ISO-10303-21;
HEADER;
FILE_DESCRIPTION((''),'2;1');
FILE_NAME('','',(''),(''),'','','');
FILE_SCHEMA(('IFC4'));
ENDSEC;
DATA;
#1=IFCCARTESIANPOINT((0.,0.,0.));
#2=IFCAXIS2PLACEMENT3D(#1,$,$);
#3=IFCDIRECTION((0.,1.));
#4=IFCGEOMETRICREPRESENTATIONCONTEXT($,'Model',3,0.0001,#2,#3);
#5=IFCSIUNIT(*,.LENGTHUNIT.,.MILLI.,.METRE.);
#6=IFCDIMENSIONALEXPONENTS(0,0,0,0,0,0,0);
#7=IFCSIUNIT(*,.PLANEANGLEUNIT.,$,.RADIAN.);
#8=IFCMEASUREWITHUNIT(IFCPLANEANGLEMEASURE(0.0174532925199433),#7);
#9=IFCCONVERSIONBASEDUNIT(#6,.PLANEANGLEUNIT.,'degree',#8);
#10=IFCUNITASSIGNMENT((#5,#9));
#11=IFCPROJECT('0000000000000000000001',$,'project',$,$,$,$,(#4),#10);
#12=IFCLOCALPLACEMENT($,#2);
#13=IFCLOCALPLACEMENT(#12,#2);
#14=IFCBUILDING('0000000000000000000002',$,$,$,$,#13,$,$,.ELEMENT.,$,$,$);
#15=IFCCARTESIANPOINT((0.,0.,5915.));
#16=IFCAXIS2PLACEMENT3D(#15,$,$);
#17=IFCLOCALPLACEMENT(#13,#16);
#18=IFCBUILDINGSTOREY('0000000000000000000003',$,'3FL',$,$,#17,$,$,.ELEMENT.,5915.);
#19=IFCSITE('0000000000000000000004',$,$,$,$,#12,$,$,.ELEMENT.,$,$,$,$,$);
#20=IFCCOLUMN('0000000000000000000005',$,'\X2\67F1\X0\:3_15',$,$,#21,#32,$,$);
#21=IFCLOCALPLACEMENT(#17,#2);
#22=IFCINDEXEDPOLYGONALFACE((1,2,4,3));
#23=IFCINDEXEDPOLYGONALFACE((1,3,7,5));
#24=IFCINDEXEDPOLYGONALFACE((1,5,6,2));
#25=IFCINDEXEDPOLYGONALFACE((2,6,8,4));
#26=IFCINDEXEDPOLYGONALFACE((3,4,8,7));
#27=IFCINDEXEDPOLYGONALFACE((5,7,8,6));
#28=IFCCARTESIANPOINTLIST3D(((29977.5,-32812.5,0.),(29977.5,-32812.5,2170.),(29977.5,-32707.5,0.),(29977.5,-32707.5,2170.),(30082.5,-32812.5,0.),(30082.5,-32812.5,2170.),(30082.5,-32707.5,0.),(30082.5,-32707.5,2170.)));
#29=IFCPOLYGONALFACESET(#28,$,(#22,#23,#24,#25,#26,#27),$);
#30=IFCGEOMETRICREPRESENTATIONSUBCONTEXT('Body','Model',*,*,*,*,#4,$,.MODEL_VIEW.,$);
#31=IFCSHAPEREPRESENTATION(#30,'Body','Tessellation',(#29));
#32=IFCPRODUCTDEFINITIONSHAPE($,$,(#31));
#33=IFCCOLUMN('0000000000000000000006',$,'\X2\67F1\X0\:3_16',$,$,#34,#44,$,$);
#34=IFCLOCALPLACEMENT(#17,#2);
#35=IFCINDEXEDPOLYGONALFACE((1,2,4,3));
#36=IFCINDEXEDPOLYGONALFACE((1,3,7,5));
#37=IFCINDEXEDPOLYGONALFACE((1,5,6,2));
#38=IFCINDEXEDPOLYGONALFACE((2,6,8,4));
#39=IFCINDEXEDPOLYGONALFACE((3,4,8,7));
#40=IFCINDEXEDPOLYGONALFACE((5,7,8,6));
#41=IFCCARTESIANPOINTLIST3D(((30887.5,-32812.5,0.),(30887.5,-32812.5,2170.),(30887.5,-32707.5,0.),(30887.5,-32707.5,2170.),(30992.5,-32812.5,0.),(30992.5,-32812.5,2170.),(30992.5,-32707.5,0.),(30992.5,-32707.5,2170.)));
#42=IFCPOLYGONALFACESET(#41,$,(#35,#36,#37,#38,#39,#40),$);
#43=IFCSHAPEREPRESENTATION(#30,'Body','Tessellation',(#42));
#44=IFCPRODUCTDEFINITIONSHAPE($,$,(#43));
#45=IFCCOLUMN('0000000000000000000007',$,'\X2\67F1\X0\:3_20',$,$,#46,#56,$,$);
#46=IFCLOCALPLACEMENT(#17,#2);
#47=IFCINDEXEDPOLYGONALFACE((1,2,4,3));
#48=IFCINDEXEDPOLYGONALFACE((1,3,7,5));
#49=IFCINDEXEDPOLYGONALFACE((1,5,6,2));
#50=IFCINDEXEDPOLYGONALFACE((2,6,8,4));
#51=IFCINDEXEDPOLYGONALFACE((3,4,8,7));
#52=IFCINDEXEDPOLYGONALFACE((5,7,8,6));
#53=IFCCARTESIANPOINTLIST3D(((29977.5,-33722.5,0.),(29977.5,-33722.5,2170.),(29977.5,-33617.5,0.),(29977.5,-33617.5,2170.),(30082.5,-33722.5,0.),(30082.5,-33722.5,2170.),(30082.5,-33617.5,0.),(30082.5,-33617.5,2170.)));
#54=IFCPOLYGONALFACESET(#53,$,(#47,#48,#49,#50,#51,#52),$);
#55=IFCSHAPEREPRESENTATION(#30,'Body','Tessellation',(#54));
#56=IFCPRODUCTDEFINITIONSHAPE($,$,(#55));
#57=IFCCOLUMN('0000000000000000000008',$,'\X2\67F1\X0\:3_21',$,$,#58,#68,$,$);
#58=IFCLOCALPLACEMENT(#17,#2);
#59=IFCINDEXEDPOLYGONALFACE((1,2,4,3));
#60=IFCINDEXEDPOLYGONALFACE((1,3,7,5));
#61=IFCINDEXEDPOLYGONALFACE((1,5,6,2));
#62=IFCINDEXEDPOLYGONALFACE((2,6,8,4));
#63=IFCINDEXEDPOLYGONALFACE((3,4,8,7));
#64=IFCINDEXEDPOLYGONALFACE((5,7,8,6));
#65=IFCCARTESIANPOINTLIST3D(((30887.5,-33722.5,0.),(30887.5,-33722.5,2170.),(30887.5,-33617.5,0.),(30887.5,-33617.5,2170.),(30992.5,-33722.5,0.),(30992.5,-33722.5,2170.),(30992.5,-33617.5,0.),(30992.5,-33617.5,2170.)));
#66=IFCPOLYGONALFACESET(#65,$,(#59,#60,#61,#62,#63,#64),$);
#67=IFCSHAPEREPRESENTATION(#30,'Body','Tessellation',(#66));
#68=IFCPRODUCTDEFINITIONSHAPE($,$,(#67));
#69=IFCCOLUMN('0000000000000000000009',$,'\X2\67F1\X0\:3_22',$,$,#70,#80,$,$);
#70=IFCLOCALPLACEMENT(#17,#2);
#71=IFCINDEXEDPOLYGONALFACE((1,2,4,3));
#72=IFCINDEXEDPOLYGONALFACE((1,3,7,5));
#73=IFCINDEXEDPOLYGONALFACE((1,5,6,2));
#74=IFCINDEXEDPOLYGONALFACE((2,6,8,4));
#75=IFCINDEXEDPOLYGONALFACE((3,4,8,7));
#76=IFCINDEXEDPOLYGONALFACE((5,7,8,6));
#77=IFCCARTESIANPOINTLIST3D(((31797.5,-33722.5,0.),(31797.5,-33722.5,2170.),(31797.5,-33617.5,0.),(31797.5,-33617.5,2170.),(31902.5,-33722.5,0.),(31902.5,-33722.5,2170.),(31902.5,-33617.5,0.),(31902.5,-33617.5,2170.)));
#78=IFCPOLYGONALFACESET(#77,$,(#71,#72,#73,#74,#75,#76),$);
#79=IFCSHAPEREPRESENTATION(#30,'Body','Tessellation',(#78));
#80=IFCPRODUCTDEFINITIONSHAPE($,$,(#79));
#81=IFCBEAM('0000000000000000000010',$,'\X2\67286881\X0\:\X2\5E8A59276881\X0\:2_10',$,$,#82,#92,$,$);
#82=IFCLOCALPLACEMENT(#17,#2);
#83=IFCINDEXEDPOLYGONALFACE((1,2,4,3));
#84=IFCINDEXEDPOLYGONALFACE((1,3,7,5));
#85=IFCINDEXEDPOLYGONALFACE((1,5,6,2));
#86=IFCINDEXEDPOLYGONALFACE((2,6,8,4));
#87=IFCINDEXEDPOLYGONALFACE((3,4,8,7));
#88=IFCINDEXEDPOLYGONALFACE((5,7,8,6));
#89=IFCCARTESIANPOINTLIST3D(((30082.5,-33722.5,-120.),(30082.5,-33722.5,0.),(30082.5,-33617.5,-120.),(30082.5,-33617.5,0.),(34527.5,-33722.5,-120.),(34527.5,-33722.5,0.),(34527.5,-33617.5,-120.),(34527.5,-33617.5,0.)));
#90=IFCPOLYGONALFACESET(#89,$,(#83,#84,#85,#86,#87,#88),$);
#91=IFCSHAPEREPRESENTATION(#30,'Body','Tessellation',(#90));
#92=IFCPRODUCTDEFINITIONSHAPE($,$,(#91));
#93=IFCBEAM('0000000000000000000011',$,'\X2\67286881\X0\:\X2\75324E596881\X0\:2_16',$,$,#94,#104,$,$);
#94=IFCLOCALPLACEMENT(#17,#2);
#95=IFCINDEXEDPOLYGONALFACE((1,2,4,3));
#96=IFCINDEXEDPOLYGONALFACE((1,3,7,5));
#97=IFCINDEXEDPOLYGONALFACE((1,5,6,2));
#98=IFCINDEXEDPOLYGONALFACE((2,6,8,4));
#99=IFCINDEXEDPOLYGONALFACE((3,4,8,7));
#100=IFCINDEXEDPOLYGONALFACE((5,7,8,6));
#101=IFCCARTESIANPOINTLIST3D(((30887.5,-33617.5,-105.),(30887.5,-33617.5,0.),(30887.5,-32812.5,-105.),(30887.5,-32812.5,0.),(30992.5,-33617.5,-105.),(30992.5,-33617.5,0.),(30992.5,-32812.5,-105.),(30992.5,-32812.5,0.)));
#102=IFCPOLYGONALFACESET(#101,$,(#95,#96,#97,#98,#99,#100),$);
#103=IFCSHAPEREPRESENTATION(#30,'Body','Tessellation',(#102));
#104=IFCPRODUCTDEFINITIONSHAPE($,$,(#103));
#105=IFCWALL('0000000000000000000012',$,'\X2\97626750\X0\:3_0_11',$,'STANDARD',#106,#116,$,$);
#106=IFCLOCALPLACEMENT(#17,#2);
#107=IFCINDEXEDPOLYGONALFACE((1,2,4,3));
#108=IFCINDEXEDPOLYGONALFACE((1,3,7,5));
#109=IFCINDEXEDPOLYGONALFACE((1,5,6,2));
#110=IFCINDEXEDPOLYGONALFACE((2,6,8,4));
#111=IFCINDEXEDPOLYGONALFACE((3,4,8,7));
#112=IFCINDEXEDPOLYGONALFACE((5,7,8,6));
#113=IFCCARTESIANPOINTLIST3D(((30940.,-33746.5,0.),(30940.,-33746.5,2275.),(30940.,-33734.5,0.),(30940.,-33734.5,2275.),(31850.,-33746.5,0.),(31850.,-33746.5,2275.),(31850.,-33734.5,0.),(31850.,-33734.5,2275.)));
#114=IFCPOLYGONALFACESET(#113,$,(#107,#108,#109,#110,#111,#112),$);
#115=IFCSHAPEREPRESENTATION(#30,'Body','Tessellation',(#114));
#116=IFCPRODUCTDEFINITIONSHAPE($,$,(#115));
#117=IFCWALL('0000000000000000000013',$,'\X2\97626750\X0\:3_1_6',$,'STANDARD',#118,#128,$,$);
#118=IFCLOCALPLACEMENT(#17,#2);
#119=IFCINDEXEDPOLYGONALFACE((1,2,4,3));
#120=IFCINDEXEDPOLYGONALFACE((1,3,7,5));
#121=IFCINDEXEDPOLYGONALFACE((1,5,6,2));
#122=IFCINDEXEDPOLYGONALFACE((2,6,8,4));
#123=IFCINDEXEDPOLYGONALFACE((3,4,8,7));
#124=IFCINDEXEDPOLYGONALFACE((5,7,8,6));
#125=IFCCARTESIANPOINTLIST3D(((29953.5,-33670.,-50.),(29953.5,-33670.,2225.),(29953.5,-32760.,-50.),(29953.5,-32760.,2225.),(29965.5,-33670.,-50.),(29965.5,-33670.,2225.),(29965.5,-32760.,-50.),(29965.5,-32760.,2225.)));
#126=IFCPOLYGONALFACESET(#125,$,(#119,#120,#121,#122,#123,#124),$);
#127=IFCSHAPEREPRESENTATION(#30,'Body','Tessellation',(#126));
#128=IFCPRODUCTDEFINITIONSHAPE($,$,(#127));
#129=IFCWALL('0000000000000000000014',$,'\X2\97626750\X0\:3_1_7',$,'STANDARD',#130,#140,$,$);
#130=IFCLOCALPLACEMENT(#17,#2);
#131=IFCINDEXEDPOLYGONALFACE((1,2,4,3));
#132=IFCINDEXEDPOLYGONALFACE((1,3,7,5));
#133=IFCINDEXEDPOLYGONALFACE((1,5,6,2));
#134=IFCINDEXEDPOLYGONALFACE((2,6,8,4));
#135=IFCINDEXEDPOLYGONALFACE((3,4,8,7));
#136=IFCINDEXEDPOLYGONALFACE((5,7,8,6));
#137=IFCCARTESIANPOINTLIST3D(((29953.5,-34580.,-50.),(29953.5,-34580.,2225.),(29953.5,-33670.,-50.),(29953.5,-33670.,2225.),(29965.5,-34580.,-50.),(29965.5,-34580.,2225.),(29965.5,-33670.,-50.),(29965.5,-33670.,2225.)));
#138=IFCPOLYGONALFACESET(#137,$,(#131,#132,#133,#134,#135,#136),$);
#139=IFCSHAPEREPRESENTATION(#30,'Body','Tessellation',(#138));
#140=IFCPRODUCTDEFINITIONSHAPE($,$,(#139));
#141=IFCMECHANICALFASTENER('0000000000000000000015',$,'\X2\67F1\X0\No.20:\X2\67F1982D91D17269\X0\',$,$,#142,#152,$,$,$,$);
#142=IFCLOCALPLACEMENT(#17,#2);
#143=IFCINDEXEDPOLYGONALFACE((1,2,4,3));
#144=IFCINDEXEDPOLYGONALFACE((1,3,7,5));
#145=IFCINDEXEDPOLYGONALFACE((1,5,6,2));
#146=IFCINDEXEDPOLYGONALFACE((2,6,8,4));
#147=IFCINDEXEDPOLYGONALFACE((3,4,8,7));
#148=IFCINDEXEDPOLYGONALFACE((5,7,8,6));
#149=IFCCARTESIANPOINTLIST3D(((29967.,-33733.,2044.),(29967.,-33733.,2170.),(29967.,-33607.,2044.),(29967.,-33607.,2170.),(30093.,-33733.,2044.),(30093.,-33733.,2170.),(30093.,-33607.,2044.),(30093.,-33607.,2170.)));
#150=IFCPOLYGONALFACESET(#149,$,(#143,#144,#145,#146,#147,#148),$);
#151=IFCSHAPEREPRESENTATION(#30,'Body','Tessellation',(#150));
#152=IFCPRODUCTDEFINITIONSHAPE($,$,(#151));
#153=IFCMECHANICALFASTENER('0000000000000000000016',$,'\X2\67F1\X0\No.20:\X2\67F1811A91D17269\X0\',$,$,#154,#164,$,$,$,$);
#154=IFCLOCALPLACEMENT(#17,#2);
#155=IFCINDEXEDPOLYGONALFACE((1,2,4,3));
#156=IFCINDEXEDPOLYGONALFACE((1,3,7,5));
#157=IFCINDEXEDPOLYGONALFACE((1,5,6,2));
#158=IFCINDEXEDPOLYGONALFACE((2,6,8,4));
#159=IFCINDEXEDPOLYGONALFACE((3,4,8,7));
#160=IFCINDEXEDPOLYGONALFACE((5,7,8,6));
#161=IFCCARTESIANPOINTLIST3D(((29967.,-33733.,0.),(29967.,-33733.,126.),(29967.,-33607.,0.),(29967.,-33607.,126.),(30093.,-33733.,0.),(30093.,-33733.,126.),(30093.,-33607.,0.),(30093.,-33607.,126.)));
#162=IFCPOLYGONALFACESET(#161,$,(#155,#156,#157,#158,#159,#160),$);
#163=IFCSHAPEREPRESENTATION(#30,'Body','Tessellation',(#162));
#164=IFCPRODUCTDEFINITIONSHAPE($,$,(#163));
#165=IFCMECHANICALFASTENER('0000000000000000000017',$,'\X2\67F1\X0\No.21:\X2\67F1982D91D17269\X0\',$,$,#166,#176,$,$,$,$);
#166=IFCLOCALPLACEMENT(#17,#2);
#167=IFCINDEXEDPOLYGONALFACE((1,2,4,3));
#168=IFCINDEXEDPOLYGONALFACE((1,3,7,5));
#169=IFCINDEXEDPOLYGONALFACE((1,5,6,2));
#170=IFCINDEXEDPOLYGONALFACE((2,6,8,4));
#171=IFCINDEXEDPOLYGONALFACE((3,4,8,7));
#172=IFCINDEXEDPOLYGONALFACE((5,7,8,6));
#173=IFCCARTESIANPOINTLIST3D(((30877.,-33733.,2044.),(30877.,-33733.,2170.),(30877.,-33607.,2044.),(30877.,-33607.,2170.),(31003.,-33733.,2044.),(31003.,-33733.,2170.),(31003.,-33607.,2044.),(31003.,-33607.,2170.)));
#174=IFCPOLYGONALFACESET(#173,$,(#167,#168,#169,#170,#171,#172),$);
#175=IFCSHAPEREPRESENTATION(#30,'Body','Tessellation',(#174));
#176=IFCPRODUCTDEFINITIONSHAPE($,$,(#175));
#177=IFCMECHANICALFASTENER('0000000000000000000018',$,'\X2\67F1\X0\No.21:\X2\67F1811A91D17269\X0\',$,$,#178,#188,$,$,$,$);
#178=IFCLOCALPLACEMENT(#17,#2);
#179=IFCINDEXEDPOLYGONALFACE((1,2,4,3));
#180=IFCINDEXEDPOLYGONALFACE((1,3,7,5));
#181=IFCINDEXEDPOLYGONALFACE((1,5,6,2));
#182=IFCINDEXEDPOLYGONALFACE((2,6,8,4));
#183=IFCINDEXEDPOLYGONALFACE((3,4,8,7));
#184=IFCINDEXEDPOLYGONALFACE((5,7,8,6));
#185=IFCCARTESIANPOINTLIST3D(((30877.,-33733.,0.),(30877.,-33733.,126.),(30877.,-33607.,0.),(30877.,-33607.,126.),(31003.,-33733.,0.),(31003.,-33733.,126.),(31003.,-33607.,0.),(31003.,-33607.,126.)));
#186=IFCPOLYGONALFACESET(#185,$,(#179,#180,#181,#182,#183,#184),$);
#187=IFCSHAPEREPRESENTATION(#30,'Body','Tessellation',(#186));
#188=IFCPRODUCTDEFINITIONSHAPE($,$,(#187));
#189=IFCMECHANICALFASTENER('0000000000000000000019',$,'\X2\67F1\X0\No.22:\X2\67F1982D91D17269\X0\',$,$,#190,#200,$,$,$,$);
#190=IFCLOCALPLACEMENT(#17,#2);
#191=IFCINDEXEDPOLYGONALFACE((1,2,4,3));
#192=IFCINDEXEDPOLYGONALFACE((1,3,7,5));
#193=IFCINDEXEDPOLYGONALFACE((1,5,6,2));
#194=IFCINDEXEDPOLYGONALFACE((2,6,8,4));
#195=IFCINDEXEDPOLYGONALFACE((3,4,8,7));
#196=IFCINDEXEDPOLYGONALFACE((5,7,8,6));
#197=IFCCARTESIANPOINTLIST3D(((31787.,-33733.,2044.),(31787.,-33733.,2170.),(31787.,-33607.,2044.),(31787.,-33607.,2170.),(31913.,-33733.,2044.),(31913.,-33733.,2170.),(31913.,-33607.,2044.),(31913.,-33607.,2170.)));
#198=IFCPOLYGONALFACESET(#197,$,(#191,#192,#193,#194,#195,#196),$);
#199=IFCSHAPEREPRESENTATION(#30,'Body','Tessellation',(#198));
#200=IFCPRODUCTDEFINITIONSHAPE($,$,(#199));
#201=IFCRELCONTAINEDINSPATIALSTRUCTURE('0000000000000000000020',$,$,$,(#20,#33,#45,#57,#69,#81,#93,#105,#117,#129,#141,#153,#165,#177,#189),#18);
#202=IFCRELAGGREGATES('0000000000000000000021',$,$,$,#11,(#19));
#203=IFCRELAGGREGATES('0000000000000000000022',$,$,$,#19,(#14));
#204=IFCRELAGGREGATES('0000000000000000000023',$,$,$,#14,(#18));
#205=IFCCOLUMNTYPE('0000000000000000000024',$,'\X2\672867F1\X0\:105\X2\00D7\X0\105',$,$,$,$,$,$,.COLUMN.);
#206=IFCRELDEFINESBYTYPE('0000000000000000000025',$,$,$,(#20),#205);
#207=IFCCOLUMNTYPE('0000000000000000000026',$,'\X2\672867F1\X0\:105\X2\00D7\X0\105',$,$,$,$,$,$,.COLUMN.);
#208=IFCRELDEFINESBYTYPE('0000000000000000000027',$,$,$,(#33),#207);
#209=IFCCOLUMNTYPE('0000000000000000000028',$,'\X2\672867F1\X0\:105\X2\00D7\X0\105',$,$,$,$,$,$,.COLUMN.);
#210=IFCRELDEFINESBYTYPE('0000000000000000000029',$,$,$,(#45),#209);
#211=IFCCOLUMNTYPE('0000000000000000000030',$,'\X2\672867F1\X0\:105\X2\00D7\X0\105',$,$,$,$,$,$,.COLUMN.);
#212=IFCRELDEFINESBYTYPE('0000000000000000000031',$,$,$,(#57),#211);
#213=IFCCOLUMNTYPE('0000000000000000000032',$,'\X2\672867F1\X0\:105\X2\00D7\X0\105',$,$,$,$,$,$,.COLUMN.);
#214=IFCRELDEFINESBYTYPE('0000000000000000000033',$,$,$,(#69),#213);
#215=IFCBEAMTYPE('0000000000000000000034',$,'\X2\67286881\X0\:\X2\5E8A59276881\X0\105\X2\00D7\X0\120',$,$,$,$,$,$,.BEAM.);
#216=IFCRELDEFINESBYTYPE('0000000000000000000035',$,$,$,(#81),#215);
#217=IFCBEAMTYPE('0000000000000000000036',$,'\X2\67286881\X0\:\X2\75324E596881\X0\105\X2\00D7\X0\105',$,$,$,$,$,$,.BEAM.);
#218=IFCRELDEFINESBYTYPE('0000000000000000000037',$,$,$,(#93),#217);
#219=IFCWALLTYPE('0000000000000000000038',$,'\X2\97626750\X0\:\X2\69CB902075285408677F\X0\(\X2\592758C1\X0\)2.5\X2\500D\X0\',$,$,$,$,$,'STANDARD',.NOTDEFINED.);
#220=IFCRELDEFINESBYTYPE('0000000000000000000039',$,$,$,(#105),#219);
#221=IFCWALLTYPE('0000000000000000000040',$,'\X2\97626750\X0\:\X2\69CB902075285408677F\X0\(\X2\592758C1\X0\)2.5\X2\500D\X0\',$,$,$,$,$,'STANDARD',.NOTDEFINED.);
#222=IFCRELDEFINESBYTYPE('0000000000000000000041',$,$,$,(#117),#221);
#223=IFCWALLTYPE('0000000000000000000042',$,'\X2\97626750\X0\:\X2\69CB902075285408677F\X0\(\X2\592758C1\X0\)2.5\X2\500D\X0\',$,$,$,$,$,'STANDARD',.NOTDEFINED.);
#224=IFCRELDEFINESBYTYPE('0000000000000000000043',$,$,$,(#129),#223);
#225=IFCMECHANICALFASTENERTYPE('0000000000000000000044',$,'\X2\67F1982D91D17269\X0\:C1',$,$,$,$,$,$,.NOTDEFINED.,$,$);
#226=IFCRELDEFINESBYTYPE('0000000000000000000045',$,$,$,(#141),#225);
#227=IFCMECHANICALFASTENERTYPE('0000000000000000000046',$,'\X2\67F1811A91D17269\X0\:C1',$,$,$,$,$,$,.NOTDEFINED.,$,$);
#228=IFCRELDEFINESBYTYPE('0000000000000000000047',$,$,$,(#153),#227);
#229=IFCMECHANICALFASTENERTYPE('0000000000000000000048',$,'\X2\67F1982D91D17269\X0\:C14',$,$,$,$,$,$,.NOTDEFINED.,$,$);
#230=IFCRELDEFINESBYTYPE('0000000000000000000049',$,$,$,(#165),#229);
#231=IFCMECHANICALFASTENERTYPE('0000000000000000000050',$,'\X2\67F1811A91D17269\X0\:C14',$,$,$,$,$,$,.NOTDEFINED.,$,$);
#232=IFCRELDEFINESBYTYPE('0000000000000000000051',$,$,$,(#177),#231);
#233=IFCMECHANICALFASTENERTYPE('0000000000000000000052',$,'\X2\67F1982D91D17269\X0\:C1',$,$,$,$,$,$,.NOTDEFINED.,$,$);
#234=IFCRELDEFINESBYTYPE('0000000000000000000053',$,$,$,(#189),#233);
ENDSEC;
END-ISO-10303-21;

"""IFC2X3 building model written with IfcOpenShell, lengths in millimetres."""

from ifc_helpers import new_model, entity, si_unit, converted_unit, direction, frame, origin, origin_with_axes, origin_2d, place, context, subcontext, project, spatial, polyline, rectangle, outline, extrude, type_object, element, save


model = new_model("IFC2X3")

# Units and contexts
model_context = context("Model", 3, precision=0.0001, world=origin(), true_north=direction((0.0, 1.0)))
body_context = subcontext(model_context, "Body", "Model", "MODEL_VIEW")
ifc_project = project(units=[si_unit("LENGTHUNIT", "METRE", prefix="MILLI"), converted_unit("PLANEANGLEUNIT", "degree", entity("IfcPlaneAngleMeasure", 0.0174532925199433), si_unit("PLANEANGLEUNIT", "RADIAN"), dimensions=[0, 0, 0, 0, 0, 0, 0])], contexts=[model_context])

# Site, building, storey
site_placement = place(None, origin())
site = spatial("IfcSite", under=ifc_project, at=site_placement, CompositionType="ELEMENT")
building_placement = place(site_placement, origin())
building = spatial("IfcBuilding", under=site, at=building_placement, CompositionType="ELEMENT")
storey_placement = place(building_placement, frame((0.0, 0.0, 5915.0)))
storey = spatial("IfcBuildingStorey", under=building, at=storey_placement, Name="3FL", CompositionType="ELEMENT", Elevation=5915.0)

# Columns
column_type_1 = type_object("IfcColumnType", Name="木柱:105×105", PredefinedType="COLUMN")
column_1_placement = place(storey_placement, frame((30030.0, -32760.0, 0.0)))
element("IfcColumn", 1, at=column_1_placement, inside=storey, type_object=column_type_1, Name="柱:3_15", context=body_context, shape_type="SweptSolid", body=[
    extrude(rectangle(XDim=105.0, YDim=105.0, at=origin_2d()), origin_with_axes(), (0.0, 0.0, 1.0), 2170.0),
])
column_type_2 = type_object("IfcColumnType", Name="木柱:105×105", PredefinedType="COLUMN")
column_2_placement = place(storey_placement, frame((30940.0, -32760.0, 0.0)))
element("IfcColumn", 2, at=column_2_placement, inside=storey, type_object=column_type_2, Name="柱:3_16", context=body_context, shape_type="SweptSolid", body=[
    extrude(rectangle(XDim=105.0, YDim=105.0, at=origin_2d()), origin_with_axes(), (0.0, 0.0, 1.0), 2170.0),
])
column_type_3 = type_object("IfcColumnType", Name="木柱:105×105", PredefinedType="COLUMN")
column_3_placement = place(storey_placement, frame((30030.0, -33670.0, 0.0)))
element("IfcColumn", 3, at=column_3_placement, inside=storey, type_object=column_type_3, Name="柱:3_20", context=body_context, shape_type="SweptSolid", body=[
    extrude(rectangle(XDim=105.0, YDim=105.0, at=origin_2d()), origin_with_axes(), (0.0, 0.0, 1.0), 2170.0),
])
column_type_4 = type_object("IfcColumnType", Name="木柱:105×105", PredefinedType="COLUMN")
column_4_placement = place(storey_placement, frame((30940.0, -33670.0, 0.0)))
element("IfcColumn", 4, at=column_4_placement, inside=storey, type_object=column_type_4, Name="柱:3_21", context=body_context, shape_type="SweptSolid", body=[
    extrude(rectangle(XDim=105.0, YDim=105.0, at=origin_2d()), origin_with_axes(), (0.0, 0.0, 1.0), 2170.0),
])
column_type_5 = type_object("IfcColumnType", Name="木柱:105×105", PredefinedType="COLUMN")
column_5_placement = place(storey_placement, frame((31850.0, -33670.0, 0.0)))
element("IfcColumn", 5, at=column_5_placement, inside=storey, type_object=column_type_5, Name="柱:3_22", context=body_context, shape_type="SweptSolid", body=[
    extrude(rectangle(XDim=105.0, YDim=105.0, at=origin_2d()), origin_with_axes(), (0.0, 0.0, 1.0), 2170.0),
])

# Beams
beam_type_1 = type_object("IfcBeamType", Name="木梁:床大梁105×120", PredefinedType="BEAM")
beam_1_placement = place(storey_placement, frame((30082.5, -33670.0, -60.0), z_axis=(1.0, 0.0, 0.0), x_axis=(0.0, 1.0, 0.0)))
element("IfcBeam", 6, at=beam_1_placement, inside=storey, type_object=beam_type_1, Name="木梁:床大梁:2_10", context=body_context, shape_type="SweptSolid", body=[
    extrude(rectangle(XDim=105.0, YDim=120.0, at=origin_2d()), origin_with_axes(), (0.0, 0.0, 1.0), 4445.0),
])
beam_type_2 = type_object("IfcBeamType", Name="木梁:甲乙梁105×105", PredefinedType="BEAM")
beam_2_placement = place(storey_placement, frame((30940.0, -32812.5, -52.5), z_axis=(0.0, -1.0, 0.0), x_axis=(1.0, 0.0, 0.0)))
element("IfcBeam", 7, at=beam_2_placement, inside=storey, type_object=beam_type_2, Name="木梁:甲乙梁:2_16", context=body_context, shape_type="SweptSolid", body=[
    extrude(rectangle(XDim=105.0, YDim=105.0, at=origin_2d()), origin_with_axes(), (0.0, 0.0, 1.0), 805.0),
])

# Walls
wall_type_1 = type_object("IfcWallType", Name="面材:構造用合板(大壁)2.5倍", ElementType="STANDARD", PredefinedType="NOTDEFINED")
wall_1_placement = place(storey_placement, frame((31395.0, -33734.5, 0.0), z_axis=(0.0, -1.0, 0.0), x_axis=(1.0, 0.0, 0.0)))
element("IfcWall", 8, at=wall_1_placement, inside=storey, type_object=wall_type_1, Name="面材:3_0_11", ObjectType="STANDARD", context=body_context, shape_type="SweptSolid", body=[
    extrude(outline(polyline([(455.0, 0.0, 0.0), (-455.0, 0.0, 0.0), (-455.0, 2275.0, 0.0), (455.0, 2275.0, 0.0), (455.0, 0.0, 0.0)])), origin_with_axes(), (0.0, 0.0, 1.0), 12.0),
])
wall_type_2 = type_object("IfcWallType", Name="面材:構造用合板(大壁)2.5倍", ElementType="STANDARD", PredefinedType="NOTDEFINED")
wall_2_placement = place(storey_placement, frame((29965.5, -33215.0, -50.0), z_axis=(-1.0, 0.0, 0.0), x_axis=(0.0, -1.0, 0.0)))
element("IfcWall", 9, at=wall_2_placement, inside=storey, type_object=wall_type_2, Name="面材:3_1_6", ObjectType="STANDARD", context=body_context, shape_type="SweptSolid", body=[
    extrude(outline(polyline([(455.0, 0.0, 0.0), (-455.0, 0.0, 0.0), (-455.0, 2275.0, 0.0), (455.0, 2275.0, 0.0), (455.0, 0.0, 0.0)])), origin_with_axes(), (0.0, 0.0, 1.0), 12.0),
])
wall_type_3 = type_object("IfcWallType", Name="面材:構造用合板(大壁)2.5倍", ElementType="STANDARD", PredefinedType="NOTDEFINED")
wall_3_placement = place(storey_placement, frame((29965.5, -34125.0, -50.0), z_axis=(-1.0, 0.0, 0.0), x_axis=(0.0, -1.0, 0.0)))
element("IfcWall", 10, at=wall_3_placement, inside=storey, type_object=wall_type_3, Name="面材:3_1_7", ObjectType="STANDARD", context=body_context, shape_type="SweptSolid", body=[
    extrude(outline(polyline([(455.0, 0.0, 0.0), (-455.0, 0.0, 0.0), (-455.0, 2275.0, 0.0), (455.0, 2275.0, 0.0), (455.0, 0.0, 0.0)])), origin_with_axes(), (0.0, 0.0, 1.0), 12.0),
])

# Mechanical fasteners
mechanical_fastener_type_1 = type_object("IfcMechanicalFastenerType", Name="柱頭金物:C1")
mechanical_fastener_1_placement = place(storey_placement, frame((30030.0, -33670.0, 2044.0)))
element("IfcMechanicalFastener", 11, at=mechanical_fastener_1_placement, inside=storey, type_object=mechanical_fastener_type_1, Name="柱No.20:柱頭金物", context=body_context, shape_type="SweptSolid", body=[
    extrude(rectangle(XDim=126.0, YDim=126.0, at=origin_2d()), origin_with_axes(), (0.0, 0.0, 1.0), 126.0),
])
mechanical_fastener_type_2 = type_object("IfcMechanicalFastenerType", Name="柱脚金物:C1")
mechanical_fastener_2_placement = place(storey_placement, frame((30030.0, -33670.0, 0.0)))
element("IfcMechanicalFastener", 12, at=mechanical_fastener_2_placement, inside=storey, type_object=mechanical_fastener_type_2, Name="柱No.20:柱脚金物", context=body_context, shape_type="SweptSolid", body=[
    extrude(rectangle(XDim=126.0, YDim=126.0, at=origin_2d()), origin_with_axes(), (0.0, 0.0, 1.0), 126.0),
])
mechanical_fastener_type_3 = type_object("IfcMechanicalFastenerType", Name="柱頭金物:C14")
mechanical_fastener_3_placement = place(storey_placement, frame((30940.0, -33670.0, 2044.0)))
element("IfcMechanicalFastener", 13, at=mechanical_fastener_3_placement, inside=storey, type_object=mechanical_fastener_type_3, Name="柱No.21:柱頭金物", context=body_context, shape_type="SweptSolid", body=[
    extrude(rectangle(XDim=126.0, YDim=126.0, at=origin_2d()), origin_with_axes(), (0.0, 0.0, 1.0), 126.0),
])
mechanical_fastener_type_4 = type_object("IfcMechanicalFastenerType", Name="柱脚金物:C14")
mechanical_fastener_4_placement = place(storey_placement, frame((30940.0, -33670.0, 0.0)))
element("IfcMechanicalFastener", 14, at=mechanical_fastener_4_placement, inside=storey, type_object=mechanical_fastener_type_4, Name="柱No.21:柱脚金物", context=body_context, shape_type="SweptSolid", body=[
    extrude(rectangle(XDim=126.0, YDim=126.0, at=origin_2d()), origin_with_axes(), (0.0, 0.0, 1.0), 126.0),
])
mechanical_fastener_type_5 = type_object("IfcMechanicalFastenerType", Name="柱頭金物:C1")
mechanical_fastener_5_placement = place(storey_placement, frame((31850.0, -33670.0, 2044.0)))
element("IfcMechanicalFastener", 15, at=mechanical_fastener_5_placement, inside=storey, type_object=mechanical_fastener_type_5, Name="柱No.22:柱頭金物", context=body_context, shape_type="SweptSolid", body=[
    extrude(rectangle(XDim=126.0, YDim=126.0, at=origin_2d()), origin_with_axes(), (0.0, 0.0, 1.0), 126.0),
])

save(model, "model.ifc")
